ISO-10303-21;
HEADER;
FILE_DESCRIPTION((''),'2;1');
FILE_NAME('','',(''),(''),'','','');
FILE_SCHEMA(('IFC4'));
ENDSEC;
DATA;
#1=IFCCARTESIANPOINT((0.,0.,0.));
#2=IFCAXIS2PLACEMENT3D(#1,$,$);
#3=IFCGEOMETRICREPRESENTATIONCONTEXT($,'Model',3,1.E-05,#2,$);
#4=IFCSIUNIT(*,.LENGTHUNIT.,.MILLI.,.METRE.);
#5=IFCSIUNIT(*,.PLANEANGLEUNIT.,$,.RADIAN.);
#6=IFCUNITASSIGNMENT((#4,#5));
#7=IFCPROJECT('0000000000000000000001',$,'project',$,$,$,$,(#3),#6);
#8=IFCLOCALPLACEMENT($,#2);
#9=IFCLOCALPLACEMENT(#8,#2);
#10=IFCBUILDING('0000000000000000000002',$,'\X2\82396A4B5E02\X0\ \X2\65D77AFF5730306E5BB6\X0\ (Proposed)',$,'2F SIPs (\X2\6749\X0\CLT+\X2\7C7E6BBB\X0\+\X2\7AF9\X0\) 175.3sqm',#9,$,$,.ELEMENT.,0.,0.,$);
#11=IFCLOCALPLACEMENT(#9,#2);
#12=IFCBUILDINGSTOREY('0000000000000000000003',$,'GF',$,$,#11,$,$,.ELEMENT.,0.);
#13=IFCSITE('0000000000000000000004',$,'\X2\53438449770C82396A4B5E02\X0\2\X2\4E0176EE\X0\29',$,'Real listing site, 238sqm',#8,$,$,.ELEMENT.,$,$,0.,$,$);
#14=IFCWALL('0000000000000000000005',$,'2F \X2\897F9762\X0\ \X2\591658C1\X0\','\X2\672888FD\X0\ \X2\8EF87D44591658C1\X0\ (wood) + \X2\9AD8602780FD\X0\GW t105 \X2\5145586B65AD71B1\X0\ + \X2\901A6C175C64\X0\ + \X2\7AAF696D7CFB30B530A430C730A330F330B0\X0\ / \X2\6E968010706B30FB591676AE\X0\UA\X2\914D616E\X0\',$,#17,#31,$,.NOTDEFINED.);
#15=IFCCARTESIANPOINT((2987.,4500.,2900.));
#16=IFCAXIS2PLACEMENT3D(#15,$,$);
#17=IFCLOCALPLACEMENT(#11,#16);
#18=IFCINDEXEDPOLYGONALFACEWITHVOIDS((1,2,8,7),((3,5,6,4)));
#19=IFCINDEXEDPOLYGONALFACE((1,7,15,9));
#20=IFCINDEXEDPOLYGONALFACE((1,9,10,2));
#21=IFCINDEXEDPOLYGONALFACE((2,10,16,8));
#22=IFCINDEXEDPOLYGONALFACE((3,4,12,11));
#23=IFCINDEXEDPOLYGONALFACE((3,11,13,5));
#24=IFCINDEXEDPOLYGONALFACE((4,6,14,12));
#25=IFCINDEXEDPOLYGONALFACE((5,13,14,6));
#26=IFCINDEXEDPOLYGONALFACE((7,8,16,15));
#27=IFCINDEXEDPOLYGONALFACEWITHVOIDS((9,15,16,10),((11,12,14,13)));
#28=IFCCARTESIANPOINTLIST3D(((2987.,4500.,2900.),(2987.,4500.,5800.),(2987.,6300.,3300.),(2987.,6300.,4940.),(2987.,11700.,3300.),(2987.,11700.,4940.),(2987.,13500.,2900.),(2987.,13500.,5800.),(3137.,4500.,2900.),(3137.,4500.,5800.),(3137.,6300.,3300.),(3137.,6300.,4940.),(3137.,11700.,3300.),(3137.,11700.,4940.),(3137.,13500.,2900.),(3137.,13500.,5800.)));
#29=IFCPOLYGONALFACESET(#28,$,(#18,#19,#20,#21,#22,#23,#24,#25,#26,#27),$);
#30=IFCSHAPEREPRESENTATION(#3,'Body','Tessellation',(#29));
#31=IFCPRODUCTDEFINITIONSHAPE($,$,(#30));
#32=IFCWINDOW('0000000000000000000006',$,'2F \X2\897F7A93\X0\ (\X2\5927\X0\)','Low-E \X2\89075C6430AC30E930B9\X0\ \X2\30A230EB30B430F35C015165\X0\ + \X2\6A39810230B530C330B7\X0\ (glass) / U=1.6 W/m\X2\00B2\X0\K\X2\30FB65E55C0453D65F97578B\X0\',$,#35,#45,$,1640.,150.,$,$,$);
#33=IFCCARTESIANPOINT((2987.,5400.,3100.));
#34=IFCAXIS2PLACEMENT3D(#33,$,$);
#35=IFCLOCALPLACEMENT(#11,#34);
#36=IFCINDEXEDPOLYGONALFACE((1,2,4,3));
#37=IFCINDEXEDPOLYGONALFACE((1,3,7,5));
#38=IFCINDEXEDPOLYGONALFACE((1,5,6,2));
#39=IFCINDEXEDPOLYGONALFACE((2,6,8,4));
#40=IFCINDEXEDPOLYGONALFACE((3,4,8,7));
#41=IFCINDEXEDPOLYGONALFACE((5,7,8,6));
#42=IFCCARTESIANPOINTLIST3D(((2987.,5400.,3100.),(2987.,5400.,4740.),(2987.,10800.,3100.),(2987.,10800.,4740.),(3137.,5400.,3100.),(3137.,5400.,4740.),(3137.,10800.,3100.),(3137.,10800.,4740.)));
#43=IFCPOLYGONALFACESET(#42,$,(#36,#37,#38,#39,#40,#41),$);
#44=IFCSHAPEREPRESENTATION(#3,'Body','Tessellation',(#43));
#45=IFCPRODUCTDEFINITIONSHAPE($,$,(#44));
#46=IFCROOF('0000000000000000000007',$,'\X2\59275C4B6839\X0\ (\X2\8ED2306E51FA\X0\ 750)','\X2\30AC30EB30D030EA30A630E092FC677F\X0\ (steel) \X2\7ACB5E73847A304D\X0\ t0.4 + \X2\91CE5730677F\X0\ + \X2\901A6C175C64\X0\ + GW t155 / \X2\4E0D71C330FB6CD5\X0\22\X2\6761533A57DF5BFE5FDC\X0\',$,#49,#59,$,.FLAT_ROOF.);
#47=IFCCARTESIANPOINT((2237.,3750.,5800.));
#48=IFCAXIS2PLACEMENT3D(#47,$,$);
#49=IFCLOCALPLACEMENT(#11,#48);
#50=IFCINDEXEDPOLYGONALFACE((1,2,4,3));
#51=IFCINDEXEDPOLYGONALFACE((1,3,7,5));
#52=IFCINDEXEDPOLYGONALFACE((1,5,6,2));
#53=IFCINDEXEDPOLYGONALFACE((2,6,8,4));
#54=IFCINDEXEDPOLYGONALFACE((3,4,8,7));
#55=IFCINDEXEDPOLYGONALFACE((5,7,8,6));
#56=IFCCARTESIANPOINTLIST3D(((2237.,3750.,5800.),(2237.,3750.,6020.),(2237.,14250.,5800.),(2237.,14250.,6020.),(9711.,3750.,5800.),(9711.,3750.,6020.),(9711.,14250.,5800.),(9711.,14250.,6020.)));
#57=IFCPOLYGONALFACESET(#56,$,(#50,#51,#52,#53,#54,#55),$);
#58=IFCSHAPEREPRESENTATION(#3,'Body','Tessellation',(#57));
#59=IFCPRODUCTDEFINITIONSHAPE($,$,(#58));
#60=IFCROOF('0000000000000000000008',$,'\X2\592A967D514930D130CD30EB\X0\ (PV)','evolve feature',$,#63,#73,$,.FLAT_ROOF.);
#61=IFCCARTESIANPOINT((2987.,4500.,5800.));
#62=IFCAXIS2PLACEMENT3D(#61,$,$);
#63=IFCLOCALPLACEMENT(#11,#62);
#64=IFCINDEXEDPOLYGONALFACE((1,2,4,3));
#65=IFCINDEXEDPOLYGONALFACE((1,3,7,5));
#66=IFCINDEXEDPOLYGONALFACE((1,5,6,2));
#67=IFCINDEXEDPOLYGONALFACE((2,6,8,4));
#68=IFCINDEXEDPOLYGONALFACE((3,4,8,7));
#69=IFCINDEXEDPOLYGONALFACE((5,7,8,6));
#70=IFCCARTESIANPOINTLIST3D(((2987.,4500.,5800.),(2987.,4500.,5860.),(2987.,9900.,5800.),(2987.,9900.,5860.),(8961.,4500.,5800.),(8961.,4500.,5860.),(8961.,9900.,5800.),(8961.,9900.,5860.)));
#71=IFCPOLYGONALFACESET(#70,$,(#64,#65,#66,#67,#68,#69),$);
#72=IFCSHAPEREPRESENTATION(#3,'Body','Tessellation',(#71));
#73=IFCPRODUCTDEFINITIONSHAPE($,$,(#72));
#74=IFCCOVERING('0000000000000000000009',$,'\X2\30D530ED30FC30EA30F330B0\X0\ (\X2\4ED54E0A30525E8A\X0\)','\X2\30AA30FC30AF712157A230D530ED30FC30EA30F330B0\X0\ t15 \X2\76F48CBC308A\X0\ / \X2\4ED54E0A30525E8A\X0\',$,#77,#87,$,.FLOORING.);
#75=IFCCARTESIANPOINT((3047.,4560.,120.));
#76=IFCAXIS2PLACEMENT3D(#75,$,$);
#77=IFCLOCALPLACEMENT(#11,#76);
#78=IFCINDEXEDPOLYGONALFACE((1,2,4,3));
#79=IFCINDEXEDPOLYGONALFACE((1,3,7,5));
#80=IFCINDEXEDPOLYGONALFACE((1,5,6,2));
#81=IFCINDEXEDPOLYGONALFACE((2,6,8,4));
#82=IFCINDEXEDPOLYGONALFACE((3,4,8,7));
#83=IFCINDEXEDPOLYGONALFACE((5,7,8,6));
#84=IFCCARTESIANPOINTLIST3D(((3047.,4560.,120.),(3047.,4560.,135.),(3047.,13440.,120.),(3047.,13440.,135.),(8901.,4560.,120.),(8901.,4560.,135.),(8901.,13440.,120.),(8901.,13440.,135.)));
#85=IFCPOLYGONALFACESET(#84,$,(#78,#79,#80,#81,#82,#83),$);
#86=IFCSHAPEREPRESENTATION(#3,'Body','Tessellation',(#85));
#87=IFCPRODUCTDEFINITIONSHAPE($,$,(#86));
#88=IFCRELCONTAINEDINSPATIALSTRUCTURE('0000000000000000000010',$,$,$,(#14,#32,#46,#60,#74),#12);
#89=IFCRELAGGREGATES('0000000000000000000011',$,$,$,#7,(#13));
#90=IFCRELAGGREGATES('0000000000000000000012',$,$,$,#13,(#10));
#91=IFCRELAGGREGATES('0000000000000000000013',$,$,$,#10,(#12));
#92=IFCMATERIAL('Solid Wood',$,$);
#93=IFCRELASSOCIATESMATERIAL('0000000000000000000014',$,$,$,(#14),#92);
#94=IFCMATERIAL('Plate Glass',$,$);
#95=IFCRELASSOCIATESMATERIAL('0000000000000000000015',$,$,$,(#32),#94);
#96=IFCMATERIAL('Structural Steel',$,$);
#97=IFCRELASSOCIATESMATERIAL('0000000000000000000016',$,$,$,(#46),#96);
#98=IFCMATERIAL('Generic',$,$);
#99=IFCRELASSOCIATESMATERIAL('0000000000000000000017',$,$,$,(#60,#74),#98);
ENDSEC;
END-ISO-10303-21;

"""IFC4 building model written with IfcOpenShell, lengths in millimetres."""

from ifc_helpers import new_model, si_unit, frame, frame_2d, origin, place, context, project, spatial, rectangle, extrude, material, element, fill, save


model = new_model("IFC4")

# Units and contexts
model_context = context("Model", 3, precision=1e-05, world=origin())
ifc_project = project(units=[si_unit("LENGTHUNIT", "METRE", prefix="MILLI"), si_unit("PLANEANGLEUNIT", "RADIAN")], contexts=[model_context])

# Site, building, storey
site_placement = place(None, origin())
site = spatial("IfcSite", under=ifc_project, at=site_placement, Name="千葉県船橋市2丁目29", ObjectType="Real listing site, 238sqm", CompositionType="ELEMENT", RefElevation=0.0)
building_placement = place(site_placement, origin())
building = spatial("IfcBuilding", under=site, at=building_placement, Name="船橋市 旗竿地の家 (Proposed)", ObjectType="2F SIPs (杉CLT+籾殻+竹) 175.3sqm", CompositionType="ELEMENT", ElevationOfRefHeight=0.0, ElevationOfTerrain=0.0)
storey_placement = place(building_placement, origin())
storey = spatial("IfcBuildingStorey", under=building, at=storey_placement, Name="GF", CompositionType="ELEMENT", Elevation=0.0)

# Shared definitions
ifc_material_1 = material(Name="Solid Wood")
ifc_material_2 = material(Name="Generic")

# Shared definitions
ifc_material_3 = material(Name="Plate Glass")

# Wall, opening, window
wall_1_placement = place(storey_placement, frame((2987.0, 4500.0, 2900.0)))
wall_1 = element("IfcWall", 1, at=wall_1_placement, inside=storey, material=ifc_material_1, Name="2F 西面 外壁", Description="木製 軸組外壁 (wood) + 高性能GW t105 充填断熱 + 通気層 + 窯業系サイディング / 準耐火・外皮UA配慮", PredefinedType="NOTDEFINED", context=model_context, shape_type="SweptSolid", body=[
    extrude(rectangle(XDim=150.0, YDim=9000.0, at=frame_2d((75.0, 4500.0))), frame((2987.0, 4500.0, 2900.0)), (0.0, 0.0, 1.0), 2900.0),
])
opening_1_placement = place(storey_placement, frame((2987.0, 5400.0, 3100.0)))
opening_1 = element("IfcOpeningElement", 2, at=opening_1_placement, cuts=wall_1, PredefinedType="NOTDEFINED", context=model_context, shape_type="SweptSolid", body=[
    extrude(rectangle(XDim=150.0, YDim=5400.0, at=frame_2d((75.0, 2700.0))), frame((2987.0, 5400.0, 3100.0)), (0.0, 0.0, 1.0), 1640.0),
])
window_1_placement = place(storey_placement, frame((2987.0, 5400.0, 3100.0)))
window_1 = element("IfcWindow", 3, at=window_1_placement, inside=storey, material=ifc_material_3, Name="2F 西窓 (大)", Description="Low-E 複層ガラス アルゴン封入 + 樹脂サッシ (glass) / U=1.6 W/m²K・日射取得型", OverallHeight=1640.0, OverallWidth=150.0, context=model_context, shape_type="SweptSolid", body=[
    extrude(rectangle(XDim=150.0, YDim=5400.0, at=frame_2d((75.0, 2700.0))), frame((2987.0, 5400.0, 3100.0)), (0.0, 0.0, 1.0), 1640.0),
])
fill(opening_1, window_1)

# Roofs
ifc_material_4 = material(Name="Structural Steel")
roof_1_placement = place(storey_placement, frame((2237.0, 3750.0, 5800.0)))
element("IfcRoof", 4, at=roof_1_placement, inside=storey, material=ifc_material_4, Name="大屋根 (軒の出 750)", Description="ガルバリウム鋼板 (steel) 立平葺き t0.4 + 野地板 + 通気層 + GW t155 / 不燃・法22条区域対応", PredefinedType="FLAT_ROOF", context=model_context, shape_type="SweptSolid", body=[
    extrude(rectangle(XDim=7474.0, YDim=10500.0, at=frame_2d((3737.0, 5250.0))), frame((2237.0, 3750.0, 5800.0)), (0.0, 0.0, 1.0), 220.0),
])
roof_2_placement = place(storey_placement, frame((2987.0, 4500.0, 5800.0)))
element("IfcRoof", 5, at=roof_2_placement, inside=storey, material=ifc_material_2, Name="太陽光パネル (PV)", Description="evolve feature", PredefinedType="FLAT_ROOF", context=model_context, shape_type="SweptSolid", body=[
    extrude(rectangle(XDim=5974.0, YDim=5400.0, at=frame_2d((2987.0, 2700.0))), frame((2987.0, 4500.0, 5800.0)), (0.0, 0.0, 1.0), 60.0),
])

# Covering
covering_placement = place(storey_placement, frame((3047.0, 4560.0, 120.0)))
element("IfcCovering", 6, at=covering_placement, inside=storey, material=ifc_material_2, Name="フローリング (仕上げ床)", Description="オーク無垢フローリング t15 直貼り / 仕上げ床", PredefinedType="FLOORING", context=model_context, shape_type="SweptSolid", body=[
    extrude(rectangle(XDim=5854.0, YDim=8880.0, at=frame_2d((2927.0, 4440.0))), frame((3047.0, 4560.0, 120.0)), (0.0, 0.0, 1.0), 15.0),
])

save(model, "model.ifc")
